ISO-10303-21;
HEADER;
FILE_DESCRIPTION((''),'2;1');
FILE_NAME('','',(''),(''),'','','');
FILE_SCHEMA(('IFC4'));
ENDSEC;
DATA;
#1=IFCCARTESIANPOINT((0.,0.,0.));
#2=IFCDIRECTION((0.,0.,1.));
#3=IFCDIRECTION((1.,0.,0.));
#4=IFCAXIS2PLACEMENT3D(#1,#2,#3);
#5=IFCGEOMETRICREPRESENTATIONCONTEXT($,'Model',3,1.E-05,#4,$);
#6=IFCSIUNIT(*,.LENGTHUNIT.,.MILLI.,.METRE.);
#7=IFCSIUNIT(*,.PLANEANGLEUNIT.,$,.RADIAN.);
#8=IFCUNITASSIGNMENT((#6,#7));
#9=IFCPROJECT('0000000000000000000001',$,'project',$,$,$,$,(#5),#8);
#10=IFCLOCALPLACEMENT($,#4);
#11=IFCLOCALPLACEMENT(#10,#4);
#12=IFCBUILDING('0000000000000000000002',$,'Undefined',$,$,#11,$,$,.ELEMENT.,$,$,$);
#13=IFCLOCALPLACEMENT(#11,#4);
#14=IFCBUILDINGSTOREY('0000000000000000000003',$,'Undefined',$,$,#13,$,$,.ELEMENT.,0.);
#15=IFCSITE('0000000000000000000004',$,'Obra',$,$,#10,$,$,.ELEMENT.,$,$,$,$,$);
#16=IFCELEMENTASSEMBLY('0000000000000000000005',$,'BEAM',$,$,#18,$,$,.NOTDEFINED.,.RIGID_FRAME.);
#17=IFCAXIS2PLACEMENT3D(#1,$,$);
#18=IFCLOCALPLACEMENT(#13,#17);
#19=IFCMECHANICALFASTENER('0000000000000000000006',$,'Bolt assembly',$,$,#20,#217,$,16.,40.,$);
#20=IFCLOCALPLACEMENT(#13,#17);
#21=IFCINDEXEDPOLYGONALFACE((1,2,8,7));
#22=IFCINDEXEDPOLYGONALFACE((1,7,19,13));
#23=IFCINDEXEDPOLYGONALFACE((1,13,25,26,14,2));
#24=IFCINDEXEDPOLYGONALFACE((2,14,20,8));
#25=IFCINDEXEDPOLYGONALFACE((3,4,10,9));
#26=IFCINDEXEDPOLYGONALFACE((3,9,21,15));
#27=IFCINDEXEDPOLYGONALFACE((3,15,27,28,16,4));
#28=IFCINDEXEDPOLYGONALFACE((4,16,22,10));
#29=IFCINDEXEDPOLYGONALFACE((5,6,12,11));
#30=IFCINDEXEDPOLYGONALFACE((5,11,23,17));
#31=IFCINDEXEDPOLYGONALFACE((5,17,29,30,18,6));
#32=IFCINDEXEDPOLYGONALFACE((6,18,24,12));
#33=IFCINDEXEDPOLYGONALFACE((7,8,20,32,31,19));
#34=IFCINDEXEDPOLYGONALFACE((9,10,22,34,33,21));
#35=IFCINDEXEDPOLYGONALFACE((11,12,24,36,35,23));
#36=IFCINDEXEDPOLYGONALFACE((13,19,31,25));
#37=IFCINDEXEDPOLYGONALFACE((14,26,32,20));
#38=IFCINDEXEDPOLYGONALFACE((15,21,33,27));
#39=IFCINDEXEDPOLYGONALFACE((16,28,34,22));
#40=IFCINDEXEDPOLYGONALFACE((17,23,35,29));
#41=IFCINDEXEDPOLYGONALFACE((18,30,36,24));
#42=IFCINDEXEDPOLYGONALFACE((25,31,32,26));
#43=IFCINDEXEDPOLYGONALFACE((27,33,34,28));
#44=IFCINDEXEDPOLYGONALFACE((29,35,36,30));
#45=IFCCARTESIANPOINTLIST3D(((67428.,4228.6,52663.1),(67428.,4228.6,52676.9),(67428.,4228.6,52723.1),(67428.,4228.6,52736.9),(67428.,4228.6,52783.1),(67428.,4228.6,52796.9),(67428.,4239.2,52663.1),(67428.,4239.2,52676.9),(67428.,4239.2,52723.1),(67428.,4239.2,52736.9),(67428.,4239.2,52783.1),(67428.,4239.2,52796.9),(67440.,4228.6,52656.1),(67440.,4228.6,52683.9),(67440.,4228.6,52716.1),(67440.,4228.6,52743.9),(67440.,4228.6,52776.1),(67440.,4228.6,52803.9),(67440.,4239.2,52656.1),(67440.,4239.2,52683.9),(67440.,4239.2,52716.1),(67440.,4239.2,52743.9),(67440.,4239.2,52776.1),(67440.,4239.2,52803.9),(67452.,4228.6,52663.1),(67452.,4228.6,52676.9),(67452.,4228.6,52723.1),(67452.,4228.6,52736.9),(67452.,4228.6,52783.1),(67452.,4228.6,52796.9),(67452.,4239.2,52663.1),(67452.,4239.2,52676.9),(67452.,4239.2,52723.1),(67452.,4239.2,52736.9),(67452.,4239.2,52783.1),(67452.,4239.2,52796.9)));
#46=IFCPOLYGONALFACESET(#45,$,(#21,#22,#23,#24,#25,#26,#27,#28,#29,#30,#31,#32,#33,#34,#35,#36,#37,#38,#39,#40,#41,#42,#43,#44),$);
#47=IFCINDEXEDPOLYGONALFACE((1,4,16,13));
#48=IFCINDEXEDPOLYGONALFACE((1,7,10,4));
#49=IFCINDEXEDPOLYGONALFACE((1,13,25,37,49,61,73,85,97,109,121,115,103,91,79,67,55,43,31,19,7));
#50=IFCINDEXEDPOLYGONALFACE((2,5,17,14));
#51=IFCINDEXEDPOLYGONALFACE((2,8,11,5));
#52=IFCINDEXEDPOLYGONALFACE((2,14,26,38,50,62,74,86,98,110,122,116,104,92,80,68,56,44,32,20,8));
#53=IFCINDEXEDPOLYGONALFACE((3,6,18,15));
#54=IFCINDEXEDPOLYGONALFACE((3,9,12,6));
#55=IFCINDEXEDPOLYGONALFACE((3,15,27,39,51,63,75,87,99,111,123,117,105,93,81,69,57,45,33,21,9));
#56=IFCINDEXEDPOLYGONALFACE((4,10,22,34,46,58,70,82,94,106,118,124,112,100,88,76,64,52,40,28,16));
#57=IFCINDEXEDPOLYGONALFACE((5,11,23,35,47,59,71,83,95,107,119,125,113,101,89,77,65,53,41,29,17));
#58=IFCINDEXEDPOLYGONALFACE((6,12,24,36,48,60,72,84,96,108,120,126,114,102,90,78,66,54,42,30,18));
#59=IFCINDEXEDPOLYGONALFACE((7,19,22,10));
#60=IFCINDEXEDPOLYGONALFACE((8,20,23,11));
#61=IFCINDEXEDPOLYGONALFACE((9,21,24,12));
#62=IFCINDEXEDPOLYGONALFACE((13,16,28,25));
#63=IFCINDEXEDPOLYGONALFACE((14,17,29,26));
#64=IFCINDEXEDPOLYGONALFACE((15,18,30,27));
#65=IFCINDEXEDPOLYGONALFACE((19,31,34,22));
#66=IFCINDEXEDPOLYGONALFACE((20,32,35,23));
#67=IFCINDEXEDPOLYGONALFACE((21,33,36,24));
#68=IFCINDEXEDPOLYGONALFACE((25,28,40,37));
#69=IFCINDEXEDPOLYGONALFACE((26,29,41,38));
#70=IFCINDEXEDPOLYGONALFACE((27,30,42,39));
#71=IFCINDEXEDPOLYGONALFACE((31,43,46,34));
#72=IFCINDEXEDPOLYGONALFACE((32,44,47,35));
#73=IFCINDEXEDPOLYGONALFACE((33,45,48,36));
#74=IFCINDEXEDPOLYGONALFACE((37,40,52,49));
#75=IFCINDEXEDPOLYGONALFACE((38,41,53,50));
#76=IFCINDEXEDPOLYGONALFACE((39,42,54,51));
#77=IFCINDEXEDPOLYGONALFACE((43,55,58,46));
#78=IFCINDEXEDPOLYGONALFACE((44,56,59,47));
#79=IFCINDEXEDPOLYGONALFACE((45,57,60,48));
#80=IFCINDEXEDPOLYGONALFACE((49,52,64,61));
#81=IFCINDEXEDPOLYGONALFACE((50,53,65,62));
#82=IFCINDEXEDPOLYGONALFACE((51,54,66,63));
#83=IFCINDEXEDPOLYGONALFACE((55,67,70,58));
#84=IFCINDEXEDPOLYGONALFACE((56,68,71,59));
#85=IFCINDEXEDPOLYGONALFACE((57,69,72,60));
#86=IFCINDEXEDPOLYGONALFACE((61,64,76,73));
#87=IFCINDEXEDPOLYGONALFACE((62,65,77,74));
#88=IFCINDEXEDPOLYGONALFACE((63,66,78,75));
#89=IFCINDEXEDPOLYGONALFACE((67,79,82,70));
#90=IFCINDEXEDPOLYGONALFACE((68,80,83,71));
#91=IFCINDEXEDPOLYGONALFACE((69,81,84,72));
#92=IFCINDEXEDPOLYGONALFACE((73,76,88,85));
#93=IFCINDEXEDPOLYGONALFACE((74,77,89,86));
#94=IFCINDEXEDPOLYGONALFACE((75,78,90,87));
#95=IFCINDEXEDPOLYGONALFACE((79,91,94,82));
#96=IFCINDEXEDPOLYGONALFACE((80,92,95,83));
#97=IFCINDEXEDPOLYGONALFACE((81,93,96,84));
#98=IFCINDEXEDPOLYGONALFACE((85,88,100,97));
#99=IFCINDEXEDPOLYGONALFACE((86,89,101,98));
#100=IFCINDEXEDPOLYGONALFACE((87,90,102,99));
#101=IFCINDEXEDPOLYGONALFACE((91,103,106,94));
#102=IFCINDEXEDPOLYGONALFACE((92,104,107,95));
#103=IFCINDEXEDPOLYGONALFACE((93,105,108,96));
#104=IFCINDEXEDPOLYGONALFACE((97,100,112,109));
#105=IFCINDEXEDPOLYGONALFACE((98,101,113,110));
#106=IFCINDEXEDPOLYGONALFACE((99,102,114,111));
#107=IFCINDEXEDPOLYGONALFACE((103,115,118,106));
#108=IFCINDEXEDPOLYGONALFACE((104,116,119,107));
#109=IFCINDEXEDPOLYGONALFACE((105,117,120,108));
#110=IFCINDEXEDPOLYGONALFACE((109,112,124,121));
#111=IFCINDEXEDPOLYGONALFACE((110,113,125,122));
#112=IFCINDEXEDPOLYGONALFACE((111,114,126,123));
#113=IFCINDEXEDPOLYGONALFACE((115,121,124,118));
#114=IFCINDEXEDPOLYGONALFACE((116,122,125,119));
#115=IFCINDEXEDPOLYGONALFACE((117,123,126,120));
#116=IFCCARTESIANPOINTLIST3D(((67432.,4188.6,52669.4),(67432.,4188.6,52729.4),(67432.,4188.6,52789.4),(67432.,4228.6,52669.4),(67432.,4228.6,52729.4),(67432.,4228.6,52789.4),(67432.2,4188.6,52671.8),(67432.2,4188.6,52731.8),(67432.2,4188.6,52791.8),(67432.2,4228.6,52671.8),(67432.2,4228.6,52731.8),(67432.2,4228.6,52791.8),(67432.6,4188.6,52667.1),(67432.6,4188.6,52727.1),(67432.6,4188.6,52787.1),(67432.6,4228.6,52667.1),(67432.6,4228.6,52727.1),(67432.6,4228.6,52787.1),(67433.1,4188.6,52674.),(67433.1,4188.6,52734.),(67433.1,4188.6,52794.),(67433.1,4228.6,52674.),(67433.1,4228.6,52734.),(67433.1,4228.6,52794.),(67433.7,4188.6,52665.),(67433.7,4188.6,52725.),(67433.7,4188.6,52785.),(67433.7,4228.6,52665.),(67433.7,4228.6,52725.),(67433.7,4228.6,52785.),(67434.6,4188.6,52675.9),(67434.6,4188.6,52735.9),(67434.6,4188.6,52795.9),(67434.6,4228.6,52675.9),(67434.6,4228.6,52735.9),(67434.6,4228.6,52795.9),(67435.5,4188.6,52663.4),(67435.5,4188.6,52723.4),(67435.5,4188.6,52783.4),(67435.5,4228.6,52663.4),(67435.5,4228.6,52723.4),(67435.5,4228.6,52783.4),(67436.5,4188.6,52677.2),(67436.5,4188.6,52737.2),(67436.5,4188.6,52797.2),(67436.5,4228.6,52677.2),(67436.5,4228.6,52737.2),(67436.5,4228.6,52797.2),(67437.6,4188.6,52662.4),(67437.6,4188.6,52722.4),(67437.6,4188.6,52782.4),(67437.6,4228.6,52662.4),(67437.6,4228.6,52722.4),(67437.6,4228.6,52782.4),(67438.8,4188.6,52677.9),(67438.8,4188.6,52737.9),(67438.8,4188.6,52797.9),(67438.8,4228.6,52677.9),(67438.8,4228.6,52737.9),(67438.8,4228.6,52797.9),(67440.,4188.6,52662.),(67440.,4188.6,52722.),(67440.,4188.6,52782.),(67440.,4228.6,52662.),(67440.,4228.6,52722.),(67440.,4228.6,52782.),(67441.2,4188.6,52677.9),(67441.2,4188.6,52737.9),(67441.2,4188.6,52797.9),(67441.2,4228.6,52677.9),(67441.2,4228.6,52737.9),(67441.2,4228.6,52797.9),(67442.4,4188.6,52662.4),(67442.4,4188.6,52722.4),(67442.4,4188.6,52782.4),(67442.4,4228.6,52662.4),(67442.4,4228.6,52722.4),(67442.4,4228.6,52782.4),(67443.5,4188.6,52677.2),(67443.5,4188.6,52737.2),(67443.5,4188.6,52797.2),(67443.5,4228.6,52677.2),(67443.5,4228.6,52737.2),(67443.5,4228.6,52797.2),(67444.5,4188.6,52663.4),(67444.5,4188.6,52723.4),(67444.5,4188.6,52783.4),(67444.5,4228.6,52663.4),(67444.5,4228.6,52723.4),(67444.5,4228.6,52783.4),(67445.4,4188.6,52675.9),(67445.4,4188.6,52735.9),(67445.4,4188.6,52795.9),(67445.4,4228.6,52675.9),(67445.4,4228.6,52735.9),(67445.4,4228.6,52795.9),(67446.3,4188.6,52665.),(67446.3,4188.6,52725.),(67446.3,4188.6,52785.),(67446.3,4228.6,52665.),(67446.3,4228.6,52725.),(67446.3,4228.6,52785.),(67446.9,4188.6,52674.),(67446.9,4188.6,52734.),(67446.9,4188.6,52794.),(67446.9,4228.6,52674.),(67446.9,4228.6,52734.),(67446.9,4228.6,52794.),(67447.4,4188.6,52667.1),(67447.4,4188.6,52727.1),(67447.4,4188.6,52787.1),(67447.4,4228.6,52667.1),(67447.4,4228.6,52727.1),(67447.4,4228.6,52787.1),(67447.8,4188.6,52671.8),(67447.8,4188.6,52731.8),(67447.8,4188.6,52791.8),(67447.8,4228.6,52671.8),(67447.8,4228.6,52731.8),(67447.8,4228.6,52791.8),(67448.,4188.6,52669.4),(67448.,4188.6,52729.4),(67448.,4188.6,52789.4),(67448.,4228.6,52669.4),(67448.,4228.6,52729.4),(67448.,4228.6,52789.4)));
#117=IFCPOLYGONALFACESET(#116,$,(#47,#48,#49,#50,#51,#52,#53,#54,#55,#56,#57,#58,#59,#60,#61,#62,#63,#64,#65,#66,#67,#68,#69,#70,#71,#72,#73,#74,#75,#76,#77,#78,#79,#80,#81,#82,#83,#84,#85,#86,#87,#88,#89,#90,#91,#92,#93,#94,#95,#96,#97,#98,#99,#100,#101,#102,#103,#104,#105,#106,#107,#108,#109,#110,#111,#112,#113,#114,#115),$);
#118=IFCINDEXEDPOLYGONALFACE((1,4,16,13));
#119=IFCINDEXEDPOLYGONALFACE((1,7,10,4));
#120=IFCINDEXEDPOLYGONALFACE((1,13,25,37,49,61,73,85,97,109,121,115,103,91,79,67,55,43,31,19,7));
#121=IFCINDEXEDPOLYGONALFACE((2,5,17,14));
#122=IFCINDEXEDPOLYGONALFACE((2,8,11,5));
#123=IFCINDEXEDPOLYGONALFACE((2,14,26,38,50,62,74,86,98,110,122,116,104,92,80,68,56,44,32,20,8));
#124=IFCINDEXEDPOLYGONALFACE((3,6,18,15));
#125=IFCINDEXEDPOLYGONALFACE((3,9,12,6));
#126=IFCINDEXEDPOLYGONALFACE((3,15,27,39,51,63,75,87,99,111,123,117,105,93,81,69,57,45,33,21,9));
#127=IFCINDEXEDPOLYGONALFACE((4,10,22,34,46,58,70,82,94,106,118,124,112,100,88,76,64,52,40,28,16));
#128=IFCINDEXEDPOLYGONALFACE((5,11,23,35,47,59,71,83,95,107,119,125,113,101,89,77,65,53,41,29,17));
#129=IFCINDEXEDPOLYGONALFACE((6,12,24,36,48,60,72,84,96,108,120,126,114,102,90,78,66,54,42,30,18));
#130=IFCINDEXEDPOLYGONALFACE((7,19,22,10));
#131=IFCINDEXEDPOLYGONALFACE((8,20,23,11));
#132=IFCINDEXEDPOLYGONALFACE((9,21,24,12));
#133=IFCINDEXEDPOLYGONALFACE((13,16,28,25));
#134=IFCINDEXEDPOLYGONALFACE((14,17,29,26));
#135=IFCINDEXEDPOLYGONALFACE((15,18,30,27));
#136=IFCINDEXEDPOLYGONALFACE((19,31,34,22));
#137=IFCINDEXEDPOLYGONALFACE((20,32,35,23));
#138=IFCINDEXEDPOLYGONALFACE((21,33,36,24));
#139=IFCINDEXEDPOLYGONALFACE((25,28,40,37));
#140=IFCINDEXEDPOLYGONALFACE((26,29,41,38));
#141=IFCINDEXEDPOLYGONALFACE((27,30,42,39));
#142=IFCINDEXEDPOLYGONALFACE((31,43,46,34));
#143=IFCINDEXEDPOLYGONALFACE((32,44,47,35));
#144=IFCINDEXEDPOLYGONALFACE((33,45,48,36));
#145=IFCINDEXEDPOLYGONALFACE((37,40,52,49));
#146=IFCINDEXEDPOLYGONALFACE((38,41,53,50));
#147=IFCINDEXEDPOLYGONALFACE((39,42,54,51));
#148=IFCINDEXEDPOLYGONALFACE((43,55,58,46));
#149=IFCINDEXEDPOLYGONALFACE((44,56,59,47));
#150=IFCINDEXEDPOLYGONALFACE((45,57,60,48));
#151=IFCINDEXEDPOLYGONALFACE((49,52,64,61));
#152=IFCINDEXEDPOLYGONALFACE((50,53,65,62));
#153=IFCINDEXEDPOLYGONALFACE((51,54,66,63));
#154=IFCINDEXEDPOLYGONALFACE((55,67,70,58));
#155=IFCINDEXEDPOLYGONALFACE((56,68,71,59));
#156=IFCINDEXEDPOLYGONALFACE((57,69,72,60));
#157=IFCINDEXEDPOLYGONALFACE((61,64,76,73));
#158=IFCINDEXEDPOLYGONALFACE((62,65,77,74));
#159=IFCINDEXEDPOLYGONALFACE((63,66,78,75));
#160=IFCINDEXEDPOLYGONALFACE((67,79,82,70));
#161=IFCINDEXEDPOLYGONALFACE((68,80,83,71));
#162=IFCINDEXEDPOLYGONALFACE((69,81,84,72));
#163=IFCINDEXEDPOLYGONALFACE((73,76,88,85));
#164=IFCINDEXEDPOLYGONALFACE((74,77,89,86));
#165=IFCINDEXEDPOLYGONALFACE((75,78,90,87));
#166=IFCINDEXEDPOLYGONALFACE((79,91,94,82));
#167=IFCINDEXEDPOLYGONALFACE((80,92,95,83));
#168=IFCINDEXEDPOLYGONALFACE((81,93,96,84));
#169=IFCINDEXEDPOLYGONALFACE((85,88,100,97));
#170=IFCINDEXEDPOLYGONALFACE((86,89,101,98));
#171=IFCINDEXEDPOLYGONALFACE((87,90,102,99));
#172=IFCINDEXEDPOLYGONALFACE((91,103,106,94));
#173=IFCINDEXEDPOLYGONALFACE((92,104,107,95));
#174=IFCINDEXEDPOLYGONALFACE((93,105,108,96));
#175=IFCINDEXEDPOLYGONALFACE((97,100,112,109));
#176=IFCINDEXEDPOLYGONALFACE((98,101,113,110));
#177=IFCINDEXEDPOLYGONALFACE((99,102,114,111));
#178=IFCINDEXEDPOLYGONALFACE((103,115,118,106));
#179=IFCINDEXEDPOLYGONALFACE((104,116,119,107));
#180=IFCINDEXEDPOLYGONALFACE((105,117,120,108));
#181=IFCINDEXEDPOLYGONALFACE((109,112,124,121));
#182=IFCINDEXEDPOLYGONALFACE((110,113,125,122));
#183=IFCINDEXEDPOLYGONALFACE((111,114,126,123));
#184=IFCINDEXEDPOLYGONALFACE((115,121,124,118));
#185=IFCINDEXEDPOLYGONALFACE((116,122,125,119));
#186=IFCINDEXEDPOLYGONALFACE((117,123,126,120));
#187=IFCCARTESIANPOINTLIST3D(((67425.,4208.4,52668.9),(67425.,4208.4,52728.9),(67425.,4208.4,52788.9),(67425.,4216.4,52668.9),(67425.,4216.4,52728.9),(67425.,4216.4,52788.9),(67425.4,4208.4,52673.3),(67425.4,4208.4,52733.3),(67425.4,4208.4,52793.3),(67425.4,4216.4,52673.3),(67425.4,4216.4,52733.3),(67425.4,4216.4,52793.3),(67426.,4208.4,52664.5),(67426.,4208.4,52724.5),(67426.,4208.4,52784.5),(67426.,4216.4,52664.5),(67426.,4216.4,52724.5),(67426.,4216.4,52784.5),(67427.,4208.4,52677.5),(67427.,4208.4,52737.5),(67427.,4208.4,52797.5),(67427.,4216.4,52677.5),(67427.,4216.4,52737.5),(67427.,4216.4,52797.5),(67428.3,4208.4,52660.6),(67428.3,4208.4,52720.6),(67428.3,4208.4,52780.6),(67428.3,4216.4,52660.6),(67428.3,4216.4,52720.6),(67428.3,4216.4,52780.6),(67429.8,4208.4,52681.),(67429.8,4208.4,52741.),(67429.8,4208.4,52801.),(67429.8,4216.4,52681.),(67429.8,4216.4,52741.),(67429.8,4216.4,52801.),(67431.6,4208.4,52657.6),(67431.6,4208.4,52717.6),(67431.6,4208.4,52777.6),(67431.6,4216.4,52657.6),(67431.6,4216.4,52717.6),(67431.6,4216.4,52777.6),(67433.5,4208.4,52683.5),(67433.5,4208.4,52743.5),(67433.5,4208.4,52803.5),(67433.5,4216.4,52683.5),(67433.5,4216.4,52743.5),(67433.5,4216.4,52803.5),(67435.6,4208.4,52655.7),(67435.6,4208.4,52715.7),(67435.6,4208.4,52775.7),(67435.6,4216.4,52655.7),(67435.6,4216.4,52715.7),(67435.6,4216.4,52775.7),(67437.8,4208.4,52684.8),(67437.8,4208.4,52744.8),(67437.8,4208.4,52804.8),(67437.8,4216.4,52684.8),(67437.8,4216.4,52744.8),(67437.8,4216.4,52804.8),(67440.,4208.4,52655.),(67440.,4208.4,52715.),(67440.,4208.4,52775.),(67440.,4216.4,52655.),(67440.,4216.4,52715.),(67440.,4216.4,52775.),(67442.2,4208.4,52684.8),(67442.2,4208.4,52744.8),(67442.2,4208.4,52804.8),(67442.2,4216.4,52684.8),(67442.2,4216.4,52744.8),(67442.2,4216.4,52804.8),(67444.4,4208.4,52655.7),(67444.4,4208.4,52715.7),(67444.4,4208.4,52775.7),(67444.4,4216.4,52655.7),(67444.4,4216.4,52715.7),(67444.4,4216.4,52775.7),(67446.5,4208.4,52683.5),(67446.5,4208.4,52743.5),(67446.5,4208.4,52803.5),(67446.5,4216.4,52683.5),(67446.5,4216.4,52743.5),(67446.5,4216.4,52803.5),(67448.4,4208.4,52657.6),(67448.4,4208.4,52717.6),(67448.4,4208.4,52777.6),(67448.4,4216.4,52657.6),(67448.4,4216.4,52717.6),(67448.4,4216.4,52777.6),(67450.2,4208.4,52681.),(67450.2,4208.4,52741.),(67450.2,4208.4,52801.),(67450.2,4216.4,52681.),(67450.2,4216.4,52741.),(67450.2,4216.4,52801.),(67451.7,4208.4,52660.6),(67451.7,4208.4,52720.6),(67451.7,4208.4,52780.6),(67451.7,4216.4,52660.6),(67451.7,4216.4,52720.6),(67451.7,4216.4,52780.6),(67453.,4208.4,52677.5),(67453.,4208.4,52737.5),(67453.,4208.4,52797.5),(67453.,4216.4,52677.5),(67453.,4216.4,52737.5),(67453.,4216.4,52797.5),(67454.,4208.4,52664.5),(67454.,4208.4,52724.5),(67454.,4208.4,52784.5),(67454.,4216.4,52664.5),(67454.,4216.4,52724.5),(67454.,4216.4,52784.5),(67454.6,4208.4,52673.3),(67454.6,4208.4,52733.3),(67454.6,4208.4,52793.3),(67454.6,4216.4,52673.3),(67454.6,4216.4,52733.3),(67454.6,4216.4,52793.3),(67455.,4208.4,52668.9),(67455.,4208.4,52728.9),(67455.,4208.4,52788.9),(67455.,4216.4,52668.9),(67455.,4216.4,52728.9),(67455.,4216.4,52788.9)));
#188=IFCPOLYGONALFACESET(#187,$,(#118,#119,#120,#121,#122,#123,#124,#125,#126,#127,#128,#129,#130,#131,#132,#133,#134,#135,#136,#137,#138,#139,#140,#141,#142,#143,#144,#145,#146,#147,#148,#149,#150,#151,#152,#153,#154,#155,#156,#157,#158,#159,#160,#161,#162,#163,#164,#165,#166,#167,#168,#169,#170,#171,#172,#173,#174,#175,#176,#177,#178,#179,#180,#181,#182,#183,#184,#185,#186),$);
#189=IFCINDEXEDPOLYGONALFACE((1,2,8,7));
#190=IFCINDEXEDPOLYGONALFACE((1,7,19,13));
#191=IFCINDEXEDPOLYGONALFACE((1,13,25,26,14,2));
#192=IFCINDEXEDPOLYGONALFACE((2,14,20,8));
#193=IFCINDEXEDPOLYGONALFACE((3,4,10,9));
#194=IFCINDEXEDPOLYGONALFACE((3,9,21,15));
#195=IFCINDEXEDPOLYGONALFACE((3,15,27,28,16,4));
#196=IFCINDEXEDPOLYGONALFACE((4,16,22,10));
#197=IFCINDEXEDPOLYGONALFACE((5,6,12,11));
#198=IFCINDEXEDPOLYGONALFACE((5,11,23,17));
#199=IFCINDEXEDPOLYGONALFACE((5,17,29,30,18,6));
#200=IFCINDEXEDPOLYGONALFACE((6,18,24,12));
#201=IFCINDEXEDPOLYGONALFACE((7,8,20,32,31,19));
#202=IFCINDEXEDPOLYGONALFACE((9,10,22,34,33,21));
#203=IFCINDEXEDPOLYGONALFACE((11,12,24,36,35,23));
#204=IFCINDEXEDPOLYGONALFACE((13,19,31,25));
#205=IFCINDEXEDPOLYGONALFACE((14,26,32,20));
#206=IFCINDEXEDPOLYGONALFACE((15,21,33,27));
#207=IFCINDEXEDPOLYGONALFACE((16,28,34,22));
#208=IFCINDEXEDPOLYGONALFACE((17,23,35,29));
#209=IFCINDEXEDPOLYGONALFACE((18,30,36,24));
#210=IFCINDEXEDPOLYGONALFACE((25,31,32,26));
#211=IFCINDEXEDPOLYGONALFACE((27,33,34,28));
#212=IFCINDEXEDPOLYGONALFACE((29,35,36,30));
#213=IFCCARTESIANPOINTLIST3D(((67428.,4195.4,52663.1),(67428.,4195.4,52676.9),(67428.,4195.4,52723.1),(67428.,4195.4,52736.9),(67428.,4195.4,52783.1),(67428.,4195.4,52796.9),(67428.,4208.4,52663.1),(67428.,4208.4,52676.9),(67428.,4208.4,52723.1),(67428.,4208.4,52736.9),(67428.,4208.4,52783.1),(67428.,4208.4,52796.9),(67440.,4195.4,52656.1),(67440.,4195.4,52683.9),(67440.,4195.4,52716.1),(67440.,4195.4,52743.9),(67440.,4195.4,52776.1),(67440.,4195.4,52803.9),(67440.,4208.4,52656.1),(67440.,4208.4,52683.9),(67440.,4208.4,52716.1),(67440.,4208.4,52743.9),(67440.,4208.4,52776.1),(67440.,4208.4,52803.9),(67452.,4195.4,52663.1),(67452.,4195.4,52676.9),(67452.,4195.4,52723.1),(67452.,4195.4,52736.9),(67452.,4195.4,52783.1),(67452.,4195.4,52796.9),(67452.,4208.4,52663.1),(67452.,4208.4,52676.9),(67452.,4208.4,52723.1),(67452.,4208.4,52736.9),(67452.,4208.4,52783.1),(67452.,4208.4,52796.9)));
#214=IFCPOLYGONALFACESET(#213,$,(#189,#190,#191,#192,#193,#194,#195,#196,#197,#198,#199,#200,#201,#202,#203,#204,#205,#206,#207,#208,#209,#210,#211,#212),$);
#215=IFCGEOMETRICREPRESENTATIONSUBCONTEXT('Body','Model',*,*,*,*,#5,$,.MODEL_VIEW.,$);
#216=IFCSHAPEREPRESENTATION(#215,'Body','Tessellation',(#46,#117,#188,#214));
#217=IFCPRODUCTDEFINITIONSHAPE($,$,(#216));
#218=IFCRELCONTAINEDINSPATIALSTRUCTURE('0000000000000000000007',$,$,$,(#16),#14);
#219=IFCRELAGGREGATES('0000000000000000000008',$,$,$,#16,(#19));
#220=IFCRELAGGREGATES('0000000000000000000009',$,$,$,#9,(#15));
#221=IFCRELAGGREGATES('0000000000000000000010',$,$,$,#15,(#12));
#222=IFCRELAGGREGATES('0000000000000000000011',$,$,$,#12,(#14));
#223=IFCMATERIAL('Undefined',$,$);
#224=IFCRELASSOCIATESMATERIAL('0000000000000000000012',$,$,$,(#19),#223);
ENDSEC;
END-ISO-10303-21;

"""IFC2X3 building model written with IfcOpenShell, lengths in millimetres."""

from ifc_helpers import new_model, si_unit, frame, origin_with_axes, origin_2d_with_axis, place, context, subcontext, project, spatial, polyline, circle, outline, extrude, source, transform, mapped, material, element, aggregate, save


model = new_model("IFC2X3")

# Units and contexts
model_context = context("Model", 3, precision=1e-05, world=origin_with_axes())
body_context = subcontext(model_context, "Body", "Model", "MODEL_VIEW")
ifc_project = project(units=[si_unit("LENGTHUNIT", "METRE", prefix="MILLI"), si_unit("PLANEANGLEUNIT", "RADIAN")], contexts=[model_context])

# Site, building, storey
site_placement = place(None, origin_with_axes())
site = spatial("IfcSite", under=ifc_project, at=site_placement, Name="Obra", CompositionType="ELEMENT")
building_placement = place(site_placement, origin_with_axes())
building = spatial("IfcBuilding", under=site, at=building_placement, Name="Undefined", CompositionType="ELEMENT")
storey_placement = place(building_placement, origin_with_axes())
storey = spatial("IfcBuildingStorey", under=building, at=storey_placement, Name="Undefined", CompositionType="ELEMENT", Elevation=0.0)

# Element assembly, mechanical fastener
assembly_1_placement = place(storey_placement, origin_with_axes())
assembly_1 = element("IfcElementAssembly", 1, at=assembly_1_placement, inside=storey, Name="BEAM", AssemblyPlace="NOTDEFINED", PredefinedType="RIGID_FRAME")
ifc_material_1 = material(Name="Undefined")
shared_shape_1 = source(origin_with_axes(), body_context, "Body", "SweptSolid", [
    extrude(outline(polyline([(13.9, 0.0), (6.9, 12.0), (-6.9, 12.0), (-13.9, 0.0), (-6.9, -12.0), (6.9, -12.0), (13.9, 0.0)])), frame((0.0, -19.7, 0.0), z_axis=(0.0, 1.0, 0.0), x_axis=(1.0, 0.0, 0.0)), (0.0, 0.0, 1.0), 10.6),
    extrude(circle(Radius=8.0, at=origin_2d_with_axis()), frame((0.0, -9.1, 0.0), z_axis=(0.0, 1.0, 0.0), x_axis=(1.0, 0.0, 0.0)), (0.0, 0.0, 1.0), 40.0),
    extrude(circle(Radius=15.0, at=origin_2d_with_axis()), frame((0.0, 3.1, 0.0), z_axis=(0.0, 1.0, 0.0), x_axis=(1.0, 0.0, 0.0)), (0.0, 0.0, 1.0), 8.0),
    extrude(outline(polyline([(13.9, 0.0), (6.9, 12.0), (-6.9, 12.0), (-13.9, 0.0), (-6.9, -12.0), (6.9, -12.0), (13.9, 0.0)])), frame((0.0, 11.1, 0.0), z_axis=(0.0, 1.0, 0.0), x_axis=(1.0, 0.0, 0.0)), (0.0, 0.0, 1.0), 13.0),
])
mechanical_fastener_1_placement = place(assembly_1_placement, frame((67490.0, 4219.5, 52850.0), z_axis=(-1.0, 0.0, 0.0), x_axis=(0.0, 0.0, -1.0)))
mechanical_fastener_1 = element("IfcMechanicalFastener", 2, at=mechanical_fastener_1_placement, material=ifc_material_1, Name="Bolt assembly", NominalDiameter=16.0, NominalLength=40.0, context=body_context, shape_type="MappedRepresentation", body=[
    mapped(shared_shape_1, transform((60.0, 0.0, 50.0))),
    mapped(shared_shape_1, transform((120.0, 0.0, 50.0))),
    mapped(shared_shape_1, transform((180.0, 0.0, 50.0))),
])
aggregate(assembly_1, [mechanical_fastener_1])

save(model, "model.ifc")
